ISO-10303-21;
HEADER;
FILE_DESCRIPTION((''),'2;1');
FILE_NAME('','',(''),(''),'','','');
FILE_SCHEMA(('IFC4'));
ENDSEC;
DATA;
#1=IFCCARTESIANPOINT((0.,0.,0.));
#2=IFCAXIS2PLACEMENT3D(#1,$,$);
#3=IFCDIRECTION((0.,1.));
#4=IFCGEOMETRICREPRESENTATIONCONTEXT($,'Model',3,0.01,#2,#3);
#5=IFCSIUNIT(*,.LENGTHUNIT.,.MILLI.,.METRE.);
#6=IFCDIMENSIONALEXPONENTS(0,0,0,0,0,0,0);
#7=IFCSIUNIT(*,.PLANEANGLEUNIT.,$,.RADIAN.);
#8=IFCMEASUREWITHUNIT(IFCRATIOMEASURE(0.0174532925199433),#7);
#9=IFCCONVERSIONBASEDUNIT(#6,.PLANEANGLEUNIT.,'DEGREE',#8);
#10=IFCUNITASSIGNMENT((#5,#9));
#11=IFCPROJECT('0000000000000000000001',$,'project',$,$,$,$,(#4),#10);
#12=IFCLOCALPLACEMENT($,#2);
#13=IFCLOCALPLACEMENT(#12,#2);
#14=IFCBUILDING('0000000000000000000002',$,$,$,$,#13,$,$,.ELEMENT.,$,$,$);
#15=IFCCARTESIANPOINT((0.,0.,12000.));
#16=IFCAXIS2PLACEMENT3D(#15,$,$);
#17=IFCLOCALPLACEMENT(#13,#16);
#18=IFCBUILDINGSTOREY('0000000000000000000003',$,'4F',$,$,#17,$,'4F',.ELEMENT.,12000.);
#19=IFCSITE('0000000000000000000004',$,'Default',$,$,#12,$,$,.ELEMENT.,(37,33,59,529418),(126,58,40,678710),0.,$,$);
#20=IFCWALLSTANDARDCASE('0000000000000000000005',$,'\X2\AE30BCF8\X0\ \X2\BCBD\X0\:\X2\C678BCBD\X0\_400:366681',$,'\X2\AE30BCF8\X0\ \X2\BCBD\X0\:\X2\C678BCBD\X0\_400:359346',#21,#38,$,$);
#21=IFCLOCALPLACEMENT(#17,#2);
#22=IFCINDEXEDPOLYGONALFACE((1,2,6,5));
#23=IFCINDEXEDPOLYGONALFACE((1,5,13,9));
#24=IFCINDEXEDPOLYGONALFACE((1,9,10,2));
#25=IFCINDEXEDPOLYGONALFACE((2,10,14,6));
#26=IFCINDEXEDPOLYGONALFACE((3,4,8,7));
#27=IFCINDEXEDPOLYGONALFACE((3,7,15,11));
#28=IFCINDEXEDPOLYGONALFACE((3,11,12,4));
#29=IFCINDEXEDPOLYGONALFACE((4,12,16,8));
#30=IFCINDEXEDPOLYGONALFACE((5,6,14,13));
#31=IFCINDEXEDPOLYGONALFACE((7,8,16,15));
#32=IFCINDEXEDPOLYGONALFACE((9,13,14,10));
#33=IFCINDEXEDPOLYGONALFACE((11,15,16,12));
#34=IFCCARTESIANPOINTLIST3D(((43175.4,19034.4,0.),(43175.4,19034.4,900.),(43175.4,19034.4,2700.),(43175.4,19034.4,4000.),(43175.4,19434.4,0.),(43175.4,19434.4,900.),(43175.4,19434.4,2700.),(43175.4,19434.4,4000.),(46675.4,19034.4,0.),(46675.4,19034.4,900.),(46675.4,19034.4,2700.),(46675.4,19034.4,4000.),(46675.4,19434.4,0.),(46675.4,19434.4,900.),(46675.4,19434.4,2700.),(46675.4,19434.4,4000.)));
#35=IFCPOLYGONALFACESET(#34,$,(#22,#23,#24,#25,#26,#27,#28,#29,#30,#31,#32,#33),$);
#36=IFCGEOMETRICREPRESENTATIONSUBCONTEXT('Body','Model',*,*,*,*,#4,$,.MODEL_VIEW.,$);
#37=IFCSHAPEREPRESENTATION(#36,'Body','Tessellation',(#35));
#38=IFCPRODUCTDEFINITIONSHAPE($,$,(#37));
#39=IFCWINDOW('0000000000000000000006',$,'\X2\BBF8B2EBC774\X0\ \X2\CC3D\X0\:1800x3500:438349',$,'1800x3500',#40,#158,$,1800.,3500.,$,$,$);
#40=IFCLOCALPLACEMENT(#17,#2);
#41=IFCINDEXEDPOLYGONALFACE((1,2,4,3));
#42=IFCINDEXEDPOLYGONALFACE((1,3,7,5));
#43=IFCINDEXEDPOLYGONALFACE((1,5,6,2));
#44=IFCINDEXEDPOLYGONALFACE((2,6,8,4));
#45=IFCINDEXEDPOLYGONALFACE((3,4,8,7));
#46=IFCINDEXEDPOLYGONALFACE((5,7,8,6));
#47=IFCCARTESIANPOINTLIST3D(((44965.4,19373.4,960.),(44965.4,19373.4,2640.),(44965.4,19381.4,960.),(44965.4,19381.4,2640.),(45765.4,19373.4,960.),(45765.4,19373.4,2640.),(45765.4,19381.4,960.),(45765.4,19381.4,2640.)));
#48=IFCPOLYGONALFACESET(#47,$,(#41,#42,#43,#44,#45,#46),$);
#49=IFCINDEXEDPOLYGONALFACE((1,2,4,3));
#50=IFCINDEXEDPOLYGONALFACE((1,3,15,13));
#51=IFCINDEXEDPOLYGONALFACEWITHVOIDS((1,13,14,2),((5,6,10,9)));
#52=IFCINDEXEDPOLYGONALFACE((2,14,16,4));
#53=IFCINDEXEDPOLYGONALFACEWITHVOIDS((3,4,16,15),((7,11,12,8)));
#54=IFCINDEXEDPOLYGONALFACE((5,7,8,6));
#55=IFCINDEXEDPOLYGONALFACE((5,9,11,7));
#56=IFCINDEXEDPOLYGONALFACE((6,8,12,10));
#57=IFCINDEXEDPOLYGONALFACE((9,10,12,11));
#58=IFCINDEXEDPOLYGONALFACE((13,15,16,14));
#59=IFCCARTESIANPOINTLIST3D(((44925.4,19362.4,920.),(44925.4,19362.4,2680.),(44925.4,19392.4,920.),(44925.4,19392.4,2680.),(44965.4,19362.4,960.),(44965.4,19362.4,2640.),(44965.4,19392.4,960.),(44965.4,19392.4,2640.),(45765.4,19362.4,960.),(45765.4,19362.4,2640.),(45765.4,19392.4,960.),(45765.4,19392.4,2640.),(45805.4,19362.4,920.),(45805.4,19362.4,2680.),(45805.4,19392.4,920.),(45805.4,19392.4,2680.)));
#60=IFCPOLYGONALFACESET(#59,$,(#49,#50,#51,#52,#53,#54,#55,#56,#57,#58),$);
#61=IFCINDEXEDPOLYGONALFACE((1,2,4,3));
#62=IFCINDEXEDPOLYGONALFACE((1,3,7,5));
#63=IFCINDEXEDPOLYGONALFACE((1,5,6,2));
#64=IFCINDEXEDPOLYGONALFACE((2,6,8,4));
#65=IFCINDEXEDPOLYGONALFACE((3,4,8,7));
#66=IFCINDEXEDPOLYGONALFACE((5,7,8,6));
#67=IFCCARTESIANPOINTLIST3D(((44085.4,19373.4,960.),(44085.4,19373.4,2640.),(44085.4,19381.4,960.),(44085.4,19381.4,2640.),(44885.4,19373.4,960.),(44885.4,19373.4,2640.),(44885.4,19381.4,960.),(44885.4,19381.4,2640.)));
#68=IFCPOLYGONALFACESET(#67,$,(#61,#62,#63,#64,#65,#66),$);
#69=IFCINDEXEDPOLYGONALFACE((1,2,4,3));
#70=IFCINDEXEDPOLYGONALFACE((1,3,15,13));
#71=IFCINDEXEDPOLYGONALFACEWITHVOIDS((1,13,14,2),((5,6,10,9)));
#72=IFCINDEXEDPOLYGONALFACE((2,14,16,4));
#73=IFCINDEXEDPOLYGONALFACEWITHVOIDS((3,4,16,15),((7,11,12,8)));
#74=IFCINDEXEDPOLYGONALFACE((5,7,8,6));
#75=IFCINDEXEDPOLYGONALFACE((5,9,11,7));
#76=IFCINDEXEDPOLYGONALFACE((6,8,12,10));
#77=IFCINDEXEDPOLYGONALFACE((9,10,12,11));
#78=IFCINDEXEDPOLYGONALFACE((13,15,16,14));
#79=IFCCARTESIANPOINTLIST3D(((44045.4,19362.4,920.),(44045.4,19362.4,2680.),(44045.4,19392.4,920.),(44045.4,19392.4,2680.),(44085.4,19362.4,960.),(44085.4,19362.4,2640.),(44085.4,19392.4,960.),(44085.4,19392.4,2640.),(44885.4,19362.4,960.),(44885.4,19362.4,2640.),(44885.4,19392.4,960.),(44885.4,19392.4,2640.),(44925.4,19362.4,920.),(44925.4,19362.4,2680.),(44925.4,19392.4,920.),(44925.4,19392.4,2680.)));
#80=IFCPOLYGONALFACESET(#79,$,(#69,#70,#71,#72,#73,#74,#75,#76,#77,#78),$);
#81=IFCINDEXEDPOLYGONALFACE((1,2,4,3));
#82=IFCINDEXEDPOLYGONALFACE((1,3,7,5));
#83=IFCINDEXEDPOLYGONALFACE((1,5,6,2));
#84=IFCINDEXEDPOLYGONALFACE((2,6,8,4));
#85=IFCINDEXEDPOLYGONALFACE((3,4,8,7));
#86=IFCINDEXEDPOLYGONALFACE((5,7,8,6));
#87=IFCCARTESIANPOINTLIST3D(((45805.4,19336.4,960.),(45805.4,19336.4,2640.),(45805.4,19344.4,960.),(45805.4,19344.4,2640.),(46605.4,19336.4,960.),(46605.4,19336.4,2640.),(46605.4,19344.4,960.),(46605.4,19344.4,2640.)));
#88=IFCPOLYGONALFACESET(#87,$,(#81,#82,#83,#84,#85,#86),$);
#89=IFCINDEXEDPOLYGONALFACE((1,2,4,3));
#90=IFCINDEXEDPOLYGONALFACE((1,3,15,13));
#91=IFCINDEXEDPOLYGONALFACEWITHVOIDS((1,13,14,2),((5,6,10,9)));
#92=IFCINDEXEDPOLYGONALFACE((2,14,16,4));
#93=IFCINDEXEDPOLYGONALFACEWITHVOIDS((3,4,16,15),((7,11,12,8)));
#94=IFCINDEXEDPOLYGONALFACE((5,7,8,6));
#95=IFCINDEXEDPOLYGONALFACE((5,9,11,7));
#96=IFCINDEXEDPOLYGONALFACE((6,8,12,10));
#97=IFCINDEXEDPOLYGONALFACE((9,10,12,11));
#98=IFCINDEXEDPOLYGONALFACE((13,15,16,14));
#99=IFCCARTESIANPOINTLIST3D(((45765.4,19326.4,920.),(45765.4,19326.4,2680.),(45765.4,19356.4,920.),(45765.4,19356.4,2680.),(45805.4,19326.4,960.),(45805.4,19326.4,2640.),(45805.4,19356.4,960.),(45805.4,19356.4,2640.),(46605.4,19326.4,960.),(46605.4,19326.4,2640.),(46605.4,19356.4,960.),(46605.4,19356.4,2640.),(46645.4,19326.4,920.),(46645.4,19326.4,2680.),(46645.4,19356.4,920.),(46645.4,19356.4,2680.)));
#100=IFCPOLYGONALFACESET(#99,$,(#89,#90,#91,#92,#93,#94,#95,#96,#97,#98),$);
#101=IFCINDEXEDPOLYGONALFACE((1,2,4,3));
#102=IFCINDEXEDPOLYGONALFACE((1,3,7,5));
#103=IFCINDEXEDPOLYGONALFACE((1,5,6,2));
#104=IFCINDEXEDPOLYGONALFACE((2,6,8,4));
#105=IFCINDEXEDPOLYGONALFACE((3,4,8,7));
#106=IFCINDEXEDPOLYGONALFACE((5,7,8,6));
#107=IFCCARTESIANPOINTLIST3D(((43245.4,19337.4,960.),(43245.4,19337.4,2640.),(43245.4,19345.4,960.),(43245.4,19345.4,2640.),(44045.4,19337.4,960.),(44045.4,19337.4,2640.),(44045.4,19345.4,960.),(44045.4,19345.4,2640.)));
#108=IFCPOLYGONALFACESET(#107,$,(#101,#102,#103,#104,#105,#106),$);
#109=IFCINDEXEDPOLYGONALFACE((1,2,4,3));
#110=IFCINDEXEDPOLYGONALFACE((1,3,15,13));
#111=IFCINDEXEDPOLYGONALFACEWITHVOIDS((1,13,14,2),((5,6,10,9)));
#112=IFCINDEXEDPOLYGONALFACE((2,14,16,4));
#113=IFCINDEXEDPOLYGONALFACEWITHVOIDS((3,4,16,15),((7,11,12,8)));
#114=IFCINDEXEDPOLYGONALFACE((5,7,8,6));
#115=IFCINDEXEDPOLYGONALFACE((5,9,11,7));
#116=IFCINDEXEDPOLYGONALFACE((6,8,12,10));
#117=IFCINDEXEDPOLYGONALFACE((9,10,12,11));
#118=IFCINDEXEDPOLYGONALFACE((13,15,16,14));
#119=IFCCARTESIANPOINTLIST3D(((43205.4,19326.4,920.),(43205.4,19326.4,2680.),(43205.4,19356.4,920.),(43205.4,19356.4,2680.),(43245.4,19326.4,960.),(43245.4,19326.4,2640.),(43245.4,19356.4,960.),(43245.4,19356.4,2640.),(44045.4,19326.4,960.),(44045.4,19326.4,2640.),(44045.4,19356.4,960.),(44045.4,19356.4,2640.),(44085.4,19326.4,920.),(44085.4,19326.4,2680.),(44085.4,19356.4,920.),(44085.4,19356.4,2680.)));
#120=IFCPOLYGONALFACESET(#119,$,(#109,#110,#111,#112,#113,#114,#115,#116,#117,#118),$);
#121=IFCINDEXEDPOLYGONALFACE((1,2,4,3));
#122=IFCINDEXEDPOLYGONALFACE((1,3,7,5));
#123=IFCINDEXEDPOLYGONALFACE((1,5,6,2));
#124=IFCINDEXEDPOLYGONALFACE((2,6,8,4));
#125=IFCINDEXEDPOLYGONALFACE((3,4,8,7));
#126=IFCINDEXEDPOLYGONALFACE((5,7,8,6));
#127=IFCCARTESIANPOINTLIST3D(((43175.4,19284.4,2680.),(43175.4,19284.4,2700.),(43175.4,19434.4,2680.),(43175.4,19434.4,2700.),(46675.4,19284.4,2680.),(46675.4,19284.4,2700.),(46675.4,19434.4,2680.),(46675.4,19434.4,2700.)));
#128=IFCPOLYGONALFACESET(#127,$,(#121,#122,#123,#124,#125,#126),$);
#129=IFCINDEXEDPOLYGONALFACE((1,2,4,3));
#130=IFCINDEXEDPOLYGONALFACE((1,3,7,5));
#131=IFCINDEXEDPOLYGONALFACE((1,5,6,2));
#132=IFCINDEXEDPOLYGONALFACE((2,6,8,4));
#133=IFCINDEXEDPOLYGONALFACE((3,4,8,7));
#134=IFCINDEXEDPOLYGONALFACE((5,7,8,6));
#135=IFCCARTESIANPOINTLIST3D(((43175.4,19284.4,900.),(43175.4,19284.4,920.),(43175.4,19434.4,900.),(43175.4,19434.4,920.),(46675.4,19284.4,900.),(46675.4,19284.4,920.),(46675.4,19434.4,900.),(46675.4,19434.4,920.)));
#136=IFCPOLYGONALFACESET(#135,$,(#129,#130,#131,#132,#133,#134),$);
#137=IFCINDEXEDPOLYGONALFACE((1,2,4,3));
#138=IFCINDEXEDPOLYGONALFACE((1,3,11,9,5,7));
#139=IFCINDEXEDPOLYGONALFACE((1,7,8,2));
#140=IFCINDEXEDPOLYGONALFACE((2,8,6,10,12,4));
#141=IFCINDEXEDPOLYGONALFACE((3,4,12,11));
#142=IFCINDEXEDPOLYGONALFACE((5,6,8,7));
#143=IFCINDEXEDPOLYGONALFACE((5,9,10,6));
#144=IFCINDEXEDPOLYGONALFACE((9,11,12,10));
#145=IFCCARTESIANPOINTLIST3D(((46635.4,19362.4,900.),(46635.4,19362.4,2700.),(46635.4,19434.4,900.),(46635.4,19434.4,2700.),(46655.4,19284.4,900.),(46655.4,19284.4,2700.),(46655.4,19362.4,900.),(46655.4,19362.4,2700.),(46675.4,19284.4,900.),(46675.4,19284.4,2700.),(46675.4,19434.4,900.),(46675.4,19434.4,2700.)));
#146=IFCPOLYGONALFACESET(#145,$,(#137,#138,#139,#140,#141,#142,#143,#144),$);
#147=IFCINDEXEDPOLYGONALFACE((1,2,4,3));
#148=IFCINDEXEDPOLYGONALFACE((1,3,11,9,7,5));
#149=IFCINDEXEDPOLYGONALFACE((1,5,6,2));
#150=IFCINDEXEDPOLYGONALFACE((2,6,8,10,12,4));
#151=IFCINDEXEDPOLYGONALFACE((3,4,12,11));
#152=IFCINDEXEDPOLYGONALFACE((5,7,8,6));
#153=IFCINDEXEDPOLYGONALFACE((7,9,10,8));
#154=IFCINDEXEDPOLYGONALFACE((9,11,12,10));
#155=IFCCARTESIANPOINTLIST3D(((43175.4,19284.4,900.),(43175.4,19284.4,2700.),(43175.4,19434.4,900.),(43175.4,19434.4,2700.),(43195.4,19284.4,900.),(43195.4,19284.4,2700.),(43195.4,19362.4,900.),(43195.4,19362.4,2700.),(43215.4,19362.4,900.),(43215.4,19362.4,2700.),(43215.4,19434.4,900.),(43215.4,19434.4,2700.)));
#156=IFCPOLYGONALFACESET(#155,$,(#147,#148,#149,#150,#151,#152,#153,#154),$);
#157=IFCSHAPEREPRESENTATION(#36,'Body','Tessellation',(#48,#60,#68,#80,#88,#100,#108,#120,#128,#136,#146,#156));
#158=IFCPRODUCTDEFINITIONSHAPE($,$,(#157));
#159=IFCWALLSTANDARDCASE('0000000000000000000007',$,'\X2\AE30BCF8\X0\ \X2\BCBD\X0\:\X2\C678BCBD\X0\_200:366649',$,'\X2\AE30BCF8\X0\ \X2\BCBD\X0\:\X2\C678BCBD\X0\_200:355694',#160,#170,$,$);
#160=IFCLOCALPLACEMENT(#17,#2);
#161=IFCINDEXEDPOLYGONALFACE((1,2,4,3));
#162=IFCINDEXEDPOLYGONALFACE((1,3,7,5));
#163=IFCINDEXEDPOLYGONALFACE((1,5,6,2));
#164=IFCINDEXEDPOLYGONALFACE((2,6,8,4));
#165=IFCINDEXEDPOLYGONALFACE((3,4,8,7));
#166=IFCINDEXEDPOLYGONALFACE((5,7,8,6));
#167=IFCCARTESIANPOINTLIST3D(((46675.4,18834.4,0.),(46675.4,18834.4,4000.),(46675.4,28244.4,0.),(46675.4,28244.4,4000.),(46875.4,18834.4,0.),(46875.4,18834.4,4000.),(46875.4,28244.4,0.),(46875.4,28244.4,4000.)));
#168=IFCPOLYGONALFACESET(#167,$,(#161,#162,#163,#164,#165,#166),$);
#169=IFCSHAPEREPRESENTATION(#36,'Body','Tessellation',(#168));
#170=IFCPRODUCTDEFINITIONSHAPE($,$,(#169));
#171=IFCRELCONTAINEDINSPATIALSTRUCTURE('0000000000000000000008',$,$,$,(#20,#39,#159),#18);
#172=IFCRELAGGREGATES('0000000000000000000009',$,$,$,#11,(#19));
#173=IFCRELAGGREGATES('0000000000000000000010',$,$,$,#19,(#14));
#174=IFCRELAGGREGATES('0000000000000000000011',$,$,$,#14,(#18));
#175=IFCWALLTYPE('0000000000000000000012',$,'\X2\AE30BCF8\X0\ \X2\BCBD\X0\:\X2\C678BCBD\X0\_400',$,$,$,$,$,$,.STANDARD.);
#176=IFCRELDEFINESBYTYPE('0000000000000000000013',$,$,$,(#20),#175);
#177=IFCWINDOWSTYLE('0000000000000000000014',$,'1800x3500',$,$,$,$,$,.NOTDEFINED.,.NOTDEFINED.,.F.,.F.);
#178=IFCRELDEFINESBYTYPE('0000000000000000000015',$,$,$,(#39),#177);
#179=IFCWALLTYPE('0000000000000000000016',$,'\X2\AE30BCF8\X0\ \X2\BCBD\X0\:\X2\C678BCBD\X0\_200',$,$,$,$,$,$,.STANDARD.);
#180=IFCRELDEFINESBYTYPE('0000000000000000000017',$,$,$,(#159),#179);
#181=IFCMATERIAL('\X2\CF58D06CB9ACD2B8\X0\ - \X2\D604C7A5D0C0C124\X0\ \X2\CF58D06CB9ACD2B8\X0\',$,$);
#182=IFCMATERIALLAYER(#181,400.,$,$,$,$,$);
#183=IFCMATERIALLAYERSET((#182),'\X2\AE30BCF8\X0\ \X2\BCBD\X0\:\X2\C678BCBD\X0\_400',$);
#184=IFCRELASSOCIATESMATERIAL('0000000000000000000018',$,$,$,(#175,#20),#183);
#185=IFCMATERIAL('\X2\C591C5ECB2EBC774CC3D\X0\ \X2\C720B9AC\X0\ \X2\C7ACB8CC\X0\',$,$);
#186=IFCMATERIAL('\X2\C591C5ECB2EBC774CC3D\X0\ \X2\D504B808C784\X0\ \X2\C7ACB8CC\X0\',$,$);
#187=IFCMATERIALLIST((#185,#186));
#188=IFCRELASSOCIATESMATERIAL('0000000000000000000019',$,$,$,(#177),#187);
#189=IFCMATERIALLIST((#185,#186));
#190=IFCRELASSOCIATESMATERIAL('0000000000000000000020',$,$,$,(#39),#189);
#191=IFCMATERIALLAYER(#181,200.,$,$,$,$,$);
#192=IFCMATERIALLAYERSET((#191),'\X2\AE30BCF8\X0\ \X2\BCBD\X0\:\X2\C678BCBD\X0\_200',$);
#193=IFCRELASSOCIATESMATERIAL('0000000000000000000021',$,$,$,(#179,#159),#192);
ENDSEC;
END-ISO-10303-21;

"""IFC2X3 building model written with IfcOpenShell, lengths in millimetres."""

from ifc_helpers import new_model, entity, si_unit, converted_unit, direction, frame, frame_2d, origin, origin_2d_with_axis, place, context, subcontext, project, spatial, polyline, rectangle, outline, extrude, source, transform, mapped, material, material_list, layer, layer_set, layer_usage, type_object, type_shapes, element, fill, save


model = new_model("IFC2X3")

# Units and contexts
model_context = context("Model", 3, precision=0.01, world=origin(), true_north=direction((0.0, 1.0)))
body_context = subcontext(model_context, "Body", "Model", "MODEL_VIEW")
ifc_project = project(units=[si_unit("LENGTHUNIT", "METRE", prefix="MILLI"), converted_unit("PLANEANGLEUNIT", "DEGREE", entity("IfcRatioMeasure", 0.0174532925199433), si_unit("PLANEANGLEUNIT", "RADIAN"), dimensions=[0, 0, 0, 0, 0, 0, 0])], contexts=[model_context])

# Site, building, storey
site_placement = place(None, origin())
site = spatial("IfcSite", under=ifc_project, at=site_placement, Name="Default", CompositionType="ELEMENT", RefLatitude=(37, 33, 59, 529418), RefLongitude=(126, 58, 40, 678710), RefElevation=0.0)
building_placement = place(site_placement, origin())
building = spatial("IfcBuilding", under=site, at=building_placement, CompositionType="ELEMENT")
storey_placement = place(building_placement, frame((0.0, 0.0, 12000.0)))
storey = spatial("IfcBuildingStorey", under=building, at=storey_placement, Name="4F", LongName="4F", CompositionType="ELEMENT", Elevation=12000.0)

# Wall, opening, window
ifc_material_1 = material(Name="콘크리트 - 현장타설 콘크리트")
ifc_layer_1 = layer(ifc_material_1, 400.0)
ifc_layer_set_1 = layer_set([ifc_layer_1], Name="기본 벽:외벽_400")
ifc_layer_usage_1 = layer_usage(ifc_layer_set_1, "AXIS2", "NEGATIVE", 200.0)
wall_type_1 = type_object("IfcWallType", Name="기본 벽:외벽_400", PredefinedType="STANDARD", material=ifc_layer_set_1)
wall_1_placement = place(storey_placement, frame((46675.4, 19234.4, 0.0), z_axis=(0.0, 0.0, 1.0), x_axis=(-1.0, 0.0, 0.0)))
wall_1 = element("IfcWallStandardCase", 1, at=wall_1_placement, inside=storey, type_object=wall_type_1, material=ifc_layer_usage_1, Name="기본 벽:외벽_400:366681", ObjectType="기본 벽:외벽_400:359346", context=body_context, shape_type="SweptSolid", body=[
    extrude(rectangle(XDim=3500.0, YDim=400.0, at=frame_2d((1750.0, 0.0), x_axis=(-1.0, 0.0))), origin(), (0.0, 0.0, 1.0), 4000.0),
])
opening_1_placement = place(wall_1_placement, frame((3500.0, 200.0, 900.0)))
opening_1 = element("IfcOpeningElement", 2, at=opening_1_placement, cuts=wall_1, ObjectType="Opening", context=body_context, shape_type="SweptSolid", body=[
    extrude(rectangle(XDim=1800.0, YDim=3500.0, at=frame_2d((900.0, 1750.0), x_axis=(1.0, 0.0))), frame((0.0, 0.0, 0.0), z_axis=(0.0, -1.0, 0.0), x_axis=(0.0, 0.0, 1.0)), (0.0, 0.0, 1.0), 400.0),
])
ifc_material_2 = material(Name="양여닫이창 유리 재료")
ifc_material_3 = material(Name="양여닫이창 프레임 재료")
ifc_material_list_1 = material_list([ifc_material_2, ifc_material_3])
ifc_material_list_2 = material_list([ifc_material_2, ifc_material_3])
window_style_1 = type_object("IfcWindowStyle", Name="1800x3500", ConstructionType="NOTDEFINED", OperationType="NOTDEFINED", ParameterTakesPrecedence=False, Sizeable=False, material=ifc_material_list_2)
shared_shape_1 = source(origin(), body_context, "Body", "SweptSolid", [
    extrude(rectangle(XDim=8.0, YDim=800.0, at=origin_2d_with_axis()), frame((2190.0, 343.0, 60.0), z_axis=(0.0, 0.0, 1.0), x_axis=(0.0, 1.0, 0.0)), (0.0, 0.0, 1.0), 1680.0),
    extrude(outline(polyline([(-880.0, -440.0), (880.0, -440.0), (880.0, 440.0), (-880.0, 440.0), (-880.0, -440.0)]), holes=[polyline([(840.0, -400.0), (-840.0, -400.0), (-840.0, 400.0), (840.0, 400.0), (840.0, -400.0)])]), frame((2190.0, 328.0, 900.0), z_axis=(0.0, 1.0, 0.0), x_axis=(0.0, 0.0, -1.0)), (0.0, 0.0, 1.0), 30.0),
    extrude(rectangle(XDim=8.0, YDim=800.0, at=frame_2d((0.0, 0.0), x_axis=(1.0, 0.0))), frame((1310.0, 343.0, 60.0), z_axis=(0.0, 0.0, 1.0), x_axis=(0.0, 1.0, 0.0)), (0.0, 0.0, 1.0), 1680.0),
    extrude(outline(polyline([(-880.0, -440.0), (880.0, -440.0), (880.0, 440.0), (-880.0, 440.0), (-880.0, -440.0)]), holes=[polyline([(840.0, -400.0), (-840.0, -400.0), (-840.0, 400.0), (840.0, 400.0), (840.0, -400.0)])]), frame((1310.0, 328.0, 900.0), z_axis=(0.0, 1.0, 0.0), x_axis=(0.0, 0.0, -1.0)), (0.0, 0.0, 1.0), 30.0),
    extrude(rectangle(XDim=8.0, YDim=800.0, at=frame_2d((0.0, 0.0), x_axis=(1.0, 0.0))), frame((3030.0, 306.0, 60.0), z_axis=(0.0, 0.0, 1.0), x_axis=(0.0, 1.0, 0.0)), (0.0, 0.0, 1.0), 1680.0),
    extrude(outline(polyline([(-880.0, -440.0), (880.0, -440.0), (880.0, 440.0), (-880.0, 440.0), (-880.0, -440.0)]), holes=[polyline([(840.0, -400.0), (-840.0, -400.0), (-840.0, 400.0), (840.0, 400.0), (840.0, -400.0)])]), frame((3030.0, 292.0, 900.0), z_axis=(0.0, 1.0, 0.0), x_axis=(0.0, 0.0, -1.0)), (0.0, 0.0, 1.0), 30.0),
    extrude(rectangle(XDim=8.0, YDim=800.0, at=frame_2d((0.0, 0.0), x_axis=(1.0, 0.0))), frame((470.0, 307.0, 60.0), z_axis=(0.0, 0.0, 1.0), x_axis=(0.0, 1.0, 0.0)), (0.0, 0.0, 1.0), 1680.0),
    extrude(outline(polyline([(-880.0, -440.0), (880.0, -440.0), (880.0, 440.0), (-880.0, 440.0), (-880.0, -440.0)]), holes=[polyline([(840.0, -400.0), (-840.0, -400.0), (-840.0, 400.0), (840.0, 400.0), (840.0, -400.0)])]), frame((470.0, 292.0, 900.0), z_axis=(0.0, 1.0, 0.0), x_axis=(0.0, 0.0, -1.0)), (0.0, 0.0, 1.0), 30.0),
    extrude(rectangle(XDim=3500.0, YDim=150.0, at=frame_2d((0.0, 0.0), x_axis=(1.0, 0.0))), frame((1750.0, 325.0, 1780.0), z_axis=(0.0, 0.0, 1.0), x_axis=(-1.0, 0.0, 0.0)), (0.0, 0.0, 1.0), 20.0),
    extrude(rectangle(XDim=3500.0, YDim=150.0, at=frame_2d((0.0, 0.0), x_axis=(1.0, 0.0))), frame((1750.0, 325.0, 0.0), z_axis=(0.0, 0.0, 1.0), x_axis=(-1.0, 0.0, 0.0)), (0.0, 0.0, 1.0), 20.0),
    extrude(outline(polyline([(-74.0, -20.0), (-2.0, -20.0), (-2.0, 0.0), (76.0, 0.0), (76.0, 20.0), (-74.0, 20.0), (-74.0, -20.0)])), frame((3480.0, 326.0, 0.0), z_axis=(0.0, 0.0, 1.0), x_axis=(0.0, -1.0, 0.0)), (0.0, 0.0, 1.0), 1800.0),
    extrude(outline(polyline([(-20.0, -74.0), (20.0, -74.0), (20.0, 76.0), (0.0, 76.0), (0.0, -2.0), (-20.0, -2.0), (-20.0, -74.0)])), frame((20.0, 326.0, 0.0), z_axis=(0.0, 0.0, 1.0), x_axis=(-1.0, 0.0, 0.0)), (0.0, 0.0, 1.0), 1800.0),
])
type_shapes(window_style_1, [shared_shape_1])
window_1_placement = place(opening_1_placement, frame((0.0, 0.0, 0.0), z_axis=(0.0, 0.0, 1.0), x_axis=(-1.0, 0.0, 0.0)))
window_1 = element("IfcWindow", 3, at=window_1_placement, inside=storey, type_object=window_style_1, material=ifc_material_list_1, Name="미닫이 창:1800x3500:438349", ObjectType="1800x3500", OverallHeight=1800.0, OverallWidth=3500.0, context=body_context, shape_type="MappedRepresentation", body=[
    mapped(shared_shape_1, transform((0.0, 0.0, 0.0), scale=1.0)),
])
fill(opening_1, window_1)

# Wall
ifc_layer_2 = layer(ifc_material_1, 200.0)
ifc_layer_set_2 = layer_set([ifc_layer_2], Name="기본 벽:외벽_200")
ifc_layer_usage_2 = layer_usage(ifc_layer_set_2, "AXIS2", "NEGATIVE", 100.0)
wall_type_2 = type_object("IfcWallType", Name="기본 벽:외벽_200", PredefinedType="STANDARD", material=ifc_layer_set_2)
wall_2_placement = place(storey_placement, frame((46775.4, 18834.4, 0.0), z_axis=(0.0, 0.0, 1.0), x_axis=(0.0, 1.0, 0.0)))
element("IfcWallStandardCase", 4, at=wall_2_placement, inside=storey, type_object=wall_type_2, material=ifc_layer_usage_2, Name="기본 벽:외벽_200:366649", ObjectType="기본 벽:외벽_200:355694", context=body_context, shape_type="SweptSolid", body=[
    extrude(rectangle(XDim=9410.0, YDim=200.0, at=frame_2d((4705.0, 0.0), x_axis=(-1.0, 0.0))), origin(), (0.0, 0.0, 1.0), 4000.0),
])

save(model, "model.ifc")
